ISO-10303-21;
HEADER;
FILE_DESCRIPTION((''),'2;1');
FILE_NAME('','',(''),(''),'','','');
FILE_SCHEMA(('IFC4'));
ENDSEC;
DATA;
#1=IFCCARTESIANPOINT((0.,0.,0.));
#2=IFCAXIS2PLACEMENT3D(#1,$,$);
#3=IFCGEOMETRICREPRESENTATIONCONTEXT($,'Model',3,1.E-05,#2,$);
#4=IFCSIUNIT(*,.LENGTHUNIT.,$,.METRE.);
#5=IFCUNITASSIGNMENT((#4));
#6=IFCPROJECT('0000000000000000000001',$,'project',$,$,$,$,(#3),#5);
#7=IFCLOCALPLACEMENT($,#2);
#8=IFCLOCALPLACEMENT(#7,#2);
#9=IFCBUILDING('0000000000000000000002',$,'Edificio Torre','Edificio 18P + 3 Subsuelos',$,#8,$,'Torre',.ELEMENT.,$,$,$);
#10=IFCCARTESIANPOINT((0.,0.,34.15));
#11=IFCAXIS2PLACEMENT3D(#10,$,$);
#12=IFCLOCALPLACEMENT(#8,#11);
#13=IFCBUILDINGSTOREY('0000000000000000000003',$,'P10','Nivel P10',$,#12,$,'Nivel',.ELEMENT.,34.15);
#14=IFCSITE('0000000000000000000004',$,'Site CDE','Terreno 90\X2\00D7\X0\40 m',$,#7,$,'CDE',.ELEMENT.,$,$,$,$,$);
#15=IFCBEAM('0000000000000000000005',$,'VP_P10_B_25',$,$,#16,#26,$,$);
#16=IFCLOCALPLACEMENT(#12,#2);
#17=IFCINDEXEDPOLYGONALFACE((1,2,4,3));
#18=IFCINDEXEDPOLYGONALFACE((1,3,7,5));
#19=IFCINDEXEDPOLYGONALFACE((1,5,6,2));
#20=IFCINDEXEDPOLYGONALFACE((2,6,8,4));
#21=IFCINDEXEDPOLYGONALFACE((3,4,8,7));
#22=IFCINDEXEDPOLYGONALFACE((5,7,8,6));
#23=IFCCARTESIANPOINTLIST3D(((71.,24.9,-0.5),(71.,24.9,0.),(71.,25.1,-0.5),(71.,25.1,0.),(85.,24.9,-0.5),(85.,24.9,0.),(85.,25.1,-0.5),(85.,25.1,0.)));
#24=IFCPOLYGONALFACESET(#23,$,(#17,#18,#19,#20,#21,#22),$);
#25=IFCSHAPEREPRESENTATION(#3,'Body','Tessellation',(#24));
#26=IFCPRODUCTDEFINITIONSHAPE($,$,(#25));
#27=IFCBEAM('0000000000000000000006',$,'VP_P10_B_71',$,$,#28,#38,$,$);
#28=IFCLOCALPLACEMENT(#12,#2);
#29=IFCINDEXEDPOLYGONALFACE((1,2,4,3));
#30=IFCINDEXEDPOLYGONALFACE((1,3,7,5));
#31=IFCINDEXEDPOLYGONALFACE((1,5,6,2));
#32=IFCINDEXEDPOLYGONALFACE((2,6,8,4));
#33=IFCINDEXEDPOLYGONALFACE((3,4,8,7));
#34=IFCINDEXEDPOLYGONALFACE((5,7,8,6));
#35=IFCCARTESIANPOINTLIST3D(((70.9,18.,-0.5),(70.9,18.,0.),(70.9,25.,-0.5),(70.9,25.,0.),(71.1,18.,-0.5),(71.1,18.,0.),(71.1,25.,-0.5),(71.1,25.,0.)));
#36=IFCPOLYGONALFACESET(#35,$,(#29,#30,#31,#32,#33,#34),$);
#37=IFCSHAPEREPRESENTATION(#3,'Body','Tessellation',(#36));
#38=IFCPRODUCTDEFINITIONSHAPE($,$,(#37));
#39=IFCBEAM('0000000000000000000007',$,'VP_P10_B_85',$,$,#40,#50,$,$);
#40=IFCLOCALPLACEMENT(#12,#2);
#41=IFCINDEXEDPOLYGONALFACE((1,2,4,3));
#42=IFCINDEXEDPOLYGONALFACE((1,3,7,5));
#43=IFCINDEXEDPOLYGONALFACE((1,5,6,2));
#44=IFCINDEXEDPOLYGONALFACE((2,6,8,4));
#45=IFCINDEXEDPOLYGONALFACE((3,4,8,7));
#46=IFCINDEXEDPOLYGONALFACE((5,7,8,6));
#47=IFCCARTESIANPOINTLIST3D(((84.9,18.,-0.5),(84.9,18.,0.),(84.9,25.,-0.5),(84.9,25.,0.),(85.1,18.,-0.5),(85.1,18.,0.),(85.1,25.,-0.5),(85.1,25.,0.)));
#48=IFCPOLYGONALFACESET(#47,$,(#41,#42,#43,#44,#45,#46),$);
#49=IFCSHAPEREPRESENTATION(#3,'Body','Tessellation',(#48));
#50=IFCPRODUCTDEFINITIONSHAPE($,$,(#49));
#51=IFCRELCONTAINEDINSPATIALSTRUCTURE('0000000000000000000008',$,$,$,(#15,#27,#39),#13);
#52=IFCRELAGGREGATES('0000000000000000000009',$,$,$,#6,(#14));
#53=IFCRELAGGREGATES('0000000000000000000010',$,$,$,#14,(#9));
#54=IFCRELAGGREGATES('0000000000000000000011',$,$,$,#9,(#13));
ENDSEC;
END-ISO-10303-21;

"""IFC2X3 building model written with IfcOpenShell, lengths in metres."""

from ifc_helpers import new_model, si_unit, frame, origin, origin_2d, place, context, project, spatial, rectangle, extrude, element, save


model = new_model("IFC2X3")

# Units and contexts
model_context = context("Model", 3, precision=1e-05, world=origin())
ifc_project = project(units=[si_unit("LENGTHUNIT", "METRE")], contexts=[model_context])

# Site, building, storey
site_placement = place(None, origin())
site = spatial("IfcSite", under=ifc_project, at=site_placement, Name="Site CDE", Description="Terreno 90×40 m", LongName="CDE", CompositionType="ELEMENT")
building_placement = place(site_placement, origin())
building = spatial("IfcBuilding", under=site, at=building_placement, Name="Edificio Torre", Description="Edificio 18P + 3 Subsuelos", LongName="Torre", CompositionType="ELEMENT")
storey_placement = place(building_placement, frame((0.0, 0.0, 34.15)))
storey = spatial("IfcBuildingStorey", under=building, at=storey_placement, Name="P10", Description="Nivel P10", LongName="Nivel", CompositionType="ELEMENT", Elevation=34.15)

# Beams
for number, where, name in (
    (1, (78.0, 25.0, -0.5), "VP_P10_B_25"),
):
    element("IfcBeam", number, at=place(storey_placement, frame(where)), inside=storey, Name=name, context=model_context, shape_type="SweptSolid", body=[
        extrude(rectangle(XDim=14.0, YDim=0.2, at=origin_2d()), origin(), (0.0, 0.0, 1.0), 0.5),
    ])
for number, where, name in (
    (2, (71.0, 21.5, -0.5), "VP_P10_B_71"),
    (3, (85.0, 21.5, -0.5), "VP_P10_B_85"),
):
    element("IfcBeam", number, at=place(storey_placement, frame(where)), inside=storey, Name=name, context=model_context, shape_type="SweptSolid", body=[
        extrude(rectangle(XDim=0.2, YDim=7.0, at=origin_2d()), origin(), (0.0, 0.0, 1.0), 0.5),
    ])

save(model, "model.ifc")
